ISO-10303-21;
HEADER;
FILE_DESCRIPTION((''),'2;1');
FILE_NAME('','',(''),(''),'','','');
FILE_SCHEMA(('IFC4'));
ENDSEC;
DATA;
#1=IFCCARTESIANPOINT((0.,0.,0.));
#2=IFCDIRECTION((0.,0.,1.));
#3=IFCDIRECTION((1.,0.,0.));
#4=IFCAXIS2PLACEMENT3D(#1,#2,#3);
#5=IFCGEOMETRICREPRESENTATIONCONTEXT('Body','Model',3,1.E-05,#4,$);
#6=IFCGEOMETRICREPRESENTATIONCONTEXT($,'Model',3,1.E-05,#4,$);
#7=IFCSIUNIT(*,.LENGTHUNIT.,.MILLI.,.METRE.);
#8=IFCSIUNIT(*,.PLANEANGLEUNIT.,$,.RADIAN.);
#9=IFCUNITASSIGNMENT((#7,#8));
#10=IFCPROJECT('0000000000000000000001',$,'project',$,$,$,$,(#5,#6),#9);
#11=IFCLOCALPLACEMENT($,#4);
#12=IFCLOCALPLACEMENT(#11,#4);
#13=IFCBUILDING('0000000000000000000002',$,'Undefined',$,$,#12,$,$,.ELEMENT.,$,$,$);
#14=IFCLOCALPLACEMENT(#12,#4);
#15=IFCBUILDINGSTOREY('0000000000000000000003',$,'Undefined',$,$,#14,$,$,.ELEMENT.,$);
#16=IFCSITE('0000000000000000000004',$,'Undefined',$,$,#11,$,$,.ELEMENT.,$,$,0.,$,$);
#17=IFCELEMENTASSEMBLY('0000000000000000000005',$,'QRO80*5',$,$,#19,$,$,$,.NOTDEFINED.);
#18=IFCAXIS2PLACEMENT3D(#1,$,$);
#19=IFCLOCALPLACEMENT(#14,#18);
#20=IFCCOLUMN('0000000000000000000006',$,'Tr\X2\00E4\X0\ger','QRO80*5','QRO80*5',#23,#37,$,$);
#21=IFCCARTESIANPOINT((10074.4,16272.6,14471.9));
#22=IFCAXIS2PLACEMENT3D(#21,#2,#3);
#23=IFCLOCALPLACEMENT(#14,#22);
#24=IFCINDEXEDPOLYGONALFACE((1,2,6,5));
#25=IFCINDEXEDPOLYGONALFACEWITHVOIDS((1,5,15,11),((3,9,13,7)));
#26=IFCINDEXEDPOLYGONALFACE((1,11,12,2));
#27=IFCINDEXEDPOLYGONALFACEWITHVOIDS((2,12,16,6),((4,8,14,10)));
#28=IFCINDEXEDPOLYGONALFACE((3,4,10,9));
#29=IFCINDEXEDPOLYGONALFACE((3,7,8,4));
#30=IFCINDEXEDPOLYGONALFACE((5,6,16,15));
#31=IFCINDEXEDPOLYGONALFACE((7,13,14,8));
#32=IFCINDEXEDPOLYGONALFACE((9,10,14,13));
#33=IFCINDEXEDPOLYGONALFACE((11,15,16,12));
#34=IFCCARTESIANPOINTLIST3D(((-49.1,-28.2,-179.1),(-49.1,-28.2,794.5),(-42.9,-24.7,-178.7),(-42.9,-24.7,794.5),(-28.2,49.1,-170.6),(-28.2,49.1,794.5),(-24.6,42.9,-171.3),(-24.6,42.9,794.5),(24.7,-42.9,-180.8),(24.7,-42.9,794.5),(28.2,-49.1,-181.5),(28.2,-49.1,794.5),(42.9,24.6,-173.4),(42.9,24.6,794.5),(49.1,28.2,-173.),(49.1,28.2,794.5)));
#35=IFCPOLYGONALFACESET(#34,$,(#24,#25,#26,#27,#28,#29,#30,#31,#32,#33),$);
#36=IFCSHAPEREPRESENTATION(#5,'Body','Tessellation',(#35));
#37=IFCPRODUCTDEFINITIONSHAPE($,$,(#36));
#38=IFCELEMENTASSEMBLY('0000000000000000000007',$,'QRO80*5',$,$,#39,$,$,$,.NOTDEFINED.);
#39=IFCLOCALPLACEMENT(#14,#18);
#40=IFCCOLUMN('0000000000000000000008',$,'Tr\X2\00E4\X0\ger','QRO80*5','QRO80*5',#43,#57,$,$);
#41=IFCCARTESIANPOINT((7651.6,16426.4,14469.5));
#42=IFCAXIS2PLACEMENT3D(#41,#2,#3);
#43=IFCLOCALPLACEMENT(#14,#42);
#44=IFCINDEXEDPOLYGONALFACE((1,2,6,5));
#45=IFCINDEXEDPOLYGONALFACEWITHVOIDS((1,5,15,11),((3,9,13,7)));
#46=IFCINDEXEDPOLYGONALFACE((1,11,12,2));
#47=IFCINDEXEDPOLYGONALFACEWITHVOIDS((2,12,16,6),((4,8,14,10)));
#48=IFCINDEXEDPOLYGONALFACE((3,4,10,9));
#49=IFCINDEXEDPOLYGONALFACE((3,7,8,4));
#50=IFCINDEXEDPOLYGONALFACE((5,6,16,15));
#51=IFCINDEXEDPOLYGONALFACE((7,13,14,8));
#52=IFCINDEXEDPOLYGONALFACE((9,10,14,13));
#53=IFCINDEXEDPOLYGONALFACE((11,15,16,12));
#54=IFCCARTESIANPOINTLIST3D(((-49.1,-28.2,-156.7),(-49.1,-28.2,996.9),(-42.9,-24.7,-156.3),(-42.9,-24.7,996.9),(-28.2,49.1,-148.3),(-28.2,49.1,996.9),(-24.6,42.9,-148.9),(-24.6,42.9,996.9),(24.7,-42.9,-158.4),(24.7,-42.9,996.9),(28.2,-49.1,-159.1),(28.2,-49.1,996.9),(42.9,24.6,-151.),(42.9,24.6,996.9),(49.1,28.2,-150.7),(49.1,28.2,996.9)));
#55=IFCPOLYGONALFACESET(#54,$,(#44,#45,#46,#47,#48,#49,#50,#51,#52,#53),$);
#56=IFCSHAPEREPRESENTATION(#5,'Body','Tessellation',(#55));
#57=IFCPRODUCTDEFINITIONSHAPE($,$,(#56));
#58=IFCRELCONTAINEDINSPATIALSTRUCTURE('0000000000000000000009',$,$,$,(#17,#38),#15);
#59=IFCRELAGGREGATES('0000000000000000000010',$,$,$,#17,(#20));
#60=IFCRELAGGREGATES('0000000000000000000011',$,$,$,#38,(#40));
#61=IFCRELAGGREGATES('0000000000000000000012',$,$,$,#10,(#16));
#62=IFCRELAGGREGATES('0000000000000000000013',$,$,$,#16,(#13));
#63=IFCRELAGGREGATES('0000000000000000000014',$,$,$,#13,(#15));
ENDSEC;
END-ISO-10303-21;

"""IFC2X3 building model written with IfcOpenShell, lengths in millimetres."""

from ifc_helpers import new_model, si_unit, frame, origin_with_axes, origin_2d_with_axis, place, context, project, spatial, hollow_rectangle, extrude, clip, halfspace, element, aggregate, save


model = new_model("IFC2X3")

# Units and contexts
model_context_1 = context("Model", 3, precision=1e-05, world=origin_with_axes(), identifier="Body")
model_context_2 = context("Model", 3, precision=1e-05, world=origin_with_axes())
ifc_project = project(units=[si_unit("LENGTHUNIT", "METRE", prefix="MILLI"), si_unit("PLANEANGLEUNIT", "RADIAN")], contexts=[model_context_1, model_context_2])

# Site, building, storey
site_placement = place(None, origin_with_axes())
site = spatial("IfcSite", under=ifc_project, at=site_placement, Name="Undefined", CompositionType="ELEMENT", RefElevation=0.0)
building_placement = place(site_placement, origin_with_axes())
building = spatial("IfcBuilding", under=site, at=building_placement, Name="Undefined", CompositionType="ELEMENT")
storey_placement = place(building_placement, origin_with_axes())
storey = spatial("IfcBuildingStorey", under=building, at=storey_placement, Name="Undefined", CompositionType="ELEMENT")

# Element assemblies, columns
assembly_1 = element("IfcElementAssembly", 1, inside=storey, Name="QRO80*5", PredefinedType="NOTDEFINED")
column_1_placement = place(storey_placement, frame((10074.4, 16272.6, 14471.9), z_axis=(0.0, 0.0, 1.0), x_axis=(1.0, 0.0, 0.0)))
column_1 = element("IfcColumn", 2, at=column_1_placement, Name="Träger", Description="QRO80*5", ObjectType="QRO80*5", context=model_context_1, shape_type="Clipping", body=[
    clip(clip(extrude(hollow_rectangle(XDim=80.0, YDim=80.0, WallThickness=5.0, at=origin_2d_with_axis()), frame((0.0, 0.0, 794.5), z_axis=(0.0, 0.0, -1.0), x_axis=(-0.261057, -0.965323, 0.0)), (0.0, 0.0, 1.0), 976.0), halfspace(frame((39.1, -2.5, -176.4), z_axis=(0.001304, -0.108856, 0.994057), x_axis=(-0.063857, -0.992038, -0.108551)), True)), halfspace(frame((38.6, -10.4, 794.5), z_axis=(-0.000017, 0.000005, -1.0), x_axis=(0.258822, 0.965925, 0.000005)), True)),
])
aggregate(assembly_1, [column_1])
assembly_2 = element("IfcElementAssembly", 3, inside=storey, Name="QRO80*5", PredefinedType="NOTDEFINED")
column_2_placement = place(storey_placement, frame((7651.6, 16426.4, 14469.5), z_axis=(0.0, 0.0, 1.0), x_axis=(1.0, 0.0, 0.0)))
column_2 = element("IfcColumn", 4, at=column_2_placement, Name="Träger", Description="QRO80*5", ObjectType="QRO80*5", context=model_context_1, shape_type="Clipping", body=[
    clip(clip(extrude(hollow_rectangle(XDim=80.0, YDim=80.0, WallThickness=5.0, at=origin_2d_with_axis()), frame((0.0, 0.0, 996.9), z_axis=(0.0, 0.0, -1.0), x_axis=(-0.261057, -0.965323, 0.0)), (0.0, 0.0, 1.0), 1156.0), halfspace(frame((-39.1, 2.5, -153.4), z_axis=(0.001304, -0.108856, 0.994057), x_axis=(0.063857, 0.992038, 0.108551)), True)), halfspace(frame((-38.6, 10.4, 996.9), z_axis=(0.0, 0.0, -1.0), x_axis=(-0.258822, -0.965925, -0.000005)), True)),
])
aggregate(assembly_2, [column_2])

save(model, "model.ifc")
